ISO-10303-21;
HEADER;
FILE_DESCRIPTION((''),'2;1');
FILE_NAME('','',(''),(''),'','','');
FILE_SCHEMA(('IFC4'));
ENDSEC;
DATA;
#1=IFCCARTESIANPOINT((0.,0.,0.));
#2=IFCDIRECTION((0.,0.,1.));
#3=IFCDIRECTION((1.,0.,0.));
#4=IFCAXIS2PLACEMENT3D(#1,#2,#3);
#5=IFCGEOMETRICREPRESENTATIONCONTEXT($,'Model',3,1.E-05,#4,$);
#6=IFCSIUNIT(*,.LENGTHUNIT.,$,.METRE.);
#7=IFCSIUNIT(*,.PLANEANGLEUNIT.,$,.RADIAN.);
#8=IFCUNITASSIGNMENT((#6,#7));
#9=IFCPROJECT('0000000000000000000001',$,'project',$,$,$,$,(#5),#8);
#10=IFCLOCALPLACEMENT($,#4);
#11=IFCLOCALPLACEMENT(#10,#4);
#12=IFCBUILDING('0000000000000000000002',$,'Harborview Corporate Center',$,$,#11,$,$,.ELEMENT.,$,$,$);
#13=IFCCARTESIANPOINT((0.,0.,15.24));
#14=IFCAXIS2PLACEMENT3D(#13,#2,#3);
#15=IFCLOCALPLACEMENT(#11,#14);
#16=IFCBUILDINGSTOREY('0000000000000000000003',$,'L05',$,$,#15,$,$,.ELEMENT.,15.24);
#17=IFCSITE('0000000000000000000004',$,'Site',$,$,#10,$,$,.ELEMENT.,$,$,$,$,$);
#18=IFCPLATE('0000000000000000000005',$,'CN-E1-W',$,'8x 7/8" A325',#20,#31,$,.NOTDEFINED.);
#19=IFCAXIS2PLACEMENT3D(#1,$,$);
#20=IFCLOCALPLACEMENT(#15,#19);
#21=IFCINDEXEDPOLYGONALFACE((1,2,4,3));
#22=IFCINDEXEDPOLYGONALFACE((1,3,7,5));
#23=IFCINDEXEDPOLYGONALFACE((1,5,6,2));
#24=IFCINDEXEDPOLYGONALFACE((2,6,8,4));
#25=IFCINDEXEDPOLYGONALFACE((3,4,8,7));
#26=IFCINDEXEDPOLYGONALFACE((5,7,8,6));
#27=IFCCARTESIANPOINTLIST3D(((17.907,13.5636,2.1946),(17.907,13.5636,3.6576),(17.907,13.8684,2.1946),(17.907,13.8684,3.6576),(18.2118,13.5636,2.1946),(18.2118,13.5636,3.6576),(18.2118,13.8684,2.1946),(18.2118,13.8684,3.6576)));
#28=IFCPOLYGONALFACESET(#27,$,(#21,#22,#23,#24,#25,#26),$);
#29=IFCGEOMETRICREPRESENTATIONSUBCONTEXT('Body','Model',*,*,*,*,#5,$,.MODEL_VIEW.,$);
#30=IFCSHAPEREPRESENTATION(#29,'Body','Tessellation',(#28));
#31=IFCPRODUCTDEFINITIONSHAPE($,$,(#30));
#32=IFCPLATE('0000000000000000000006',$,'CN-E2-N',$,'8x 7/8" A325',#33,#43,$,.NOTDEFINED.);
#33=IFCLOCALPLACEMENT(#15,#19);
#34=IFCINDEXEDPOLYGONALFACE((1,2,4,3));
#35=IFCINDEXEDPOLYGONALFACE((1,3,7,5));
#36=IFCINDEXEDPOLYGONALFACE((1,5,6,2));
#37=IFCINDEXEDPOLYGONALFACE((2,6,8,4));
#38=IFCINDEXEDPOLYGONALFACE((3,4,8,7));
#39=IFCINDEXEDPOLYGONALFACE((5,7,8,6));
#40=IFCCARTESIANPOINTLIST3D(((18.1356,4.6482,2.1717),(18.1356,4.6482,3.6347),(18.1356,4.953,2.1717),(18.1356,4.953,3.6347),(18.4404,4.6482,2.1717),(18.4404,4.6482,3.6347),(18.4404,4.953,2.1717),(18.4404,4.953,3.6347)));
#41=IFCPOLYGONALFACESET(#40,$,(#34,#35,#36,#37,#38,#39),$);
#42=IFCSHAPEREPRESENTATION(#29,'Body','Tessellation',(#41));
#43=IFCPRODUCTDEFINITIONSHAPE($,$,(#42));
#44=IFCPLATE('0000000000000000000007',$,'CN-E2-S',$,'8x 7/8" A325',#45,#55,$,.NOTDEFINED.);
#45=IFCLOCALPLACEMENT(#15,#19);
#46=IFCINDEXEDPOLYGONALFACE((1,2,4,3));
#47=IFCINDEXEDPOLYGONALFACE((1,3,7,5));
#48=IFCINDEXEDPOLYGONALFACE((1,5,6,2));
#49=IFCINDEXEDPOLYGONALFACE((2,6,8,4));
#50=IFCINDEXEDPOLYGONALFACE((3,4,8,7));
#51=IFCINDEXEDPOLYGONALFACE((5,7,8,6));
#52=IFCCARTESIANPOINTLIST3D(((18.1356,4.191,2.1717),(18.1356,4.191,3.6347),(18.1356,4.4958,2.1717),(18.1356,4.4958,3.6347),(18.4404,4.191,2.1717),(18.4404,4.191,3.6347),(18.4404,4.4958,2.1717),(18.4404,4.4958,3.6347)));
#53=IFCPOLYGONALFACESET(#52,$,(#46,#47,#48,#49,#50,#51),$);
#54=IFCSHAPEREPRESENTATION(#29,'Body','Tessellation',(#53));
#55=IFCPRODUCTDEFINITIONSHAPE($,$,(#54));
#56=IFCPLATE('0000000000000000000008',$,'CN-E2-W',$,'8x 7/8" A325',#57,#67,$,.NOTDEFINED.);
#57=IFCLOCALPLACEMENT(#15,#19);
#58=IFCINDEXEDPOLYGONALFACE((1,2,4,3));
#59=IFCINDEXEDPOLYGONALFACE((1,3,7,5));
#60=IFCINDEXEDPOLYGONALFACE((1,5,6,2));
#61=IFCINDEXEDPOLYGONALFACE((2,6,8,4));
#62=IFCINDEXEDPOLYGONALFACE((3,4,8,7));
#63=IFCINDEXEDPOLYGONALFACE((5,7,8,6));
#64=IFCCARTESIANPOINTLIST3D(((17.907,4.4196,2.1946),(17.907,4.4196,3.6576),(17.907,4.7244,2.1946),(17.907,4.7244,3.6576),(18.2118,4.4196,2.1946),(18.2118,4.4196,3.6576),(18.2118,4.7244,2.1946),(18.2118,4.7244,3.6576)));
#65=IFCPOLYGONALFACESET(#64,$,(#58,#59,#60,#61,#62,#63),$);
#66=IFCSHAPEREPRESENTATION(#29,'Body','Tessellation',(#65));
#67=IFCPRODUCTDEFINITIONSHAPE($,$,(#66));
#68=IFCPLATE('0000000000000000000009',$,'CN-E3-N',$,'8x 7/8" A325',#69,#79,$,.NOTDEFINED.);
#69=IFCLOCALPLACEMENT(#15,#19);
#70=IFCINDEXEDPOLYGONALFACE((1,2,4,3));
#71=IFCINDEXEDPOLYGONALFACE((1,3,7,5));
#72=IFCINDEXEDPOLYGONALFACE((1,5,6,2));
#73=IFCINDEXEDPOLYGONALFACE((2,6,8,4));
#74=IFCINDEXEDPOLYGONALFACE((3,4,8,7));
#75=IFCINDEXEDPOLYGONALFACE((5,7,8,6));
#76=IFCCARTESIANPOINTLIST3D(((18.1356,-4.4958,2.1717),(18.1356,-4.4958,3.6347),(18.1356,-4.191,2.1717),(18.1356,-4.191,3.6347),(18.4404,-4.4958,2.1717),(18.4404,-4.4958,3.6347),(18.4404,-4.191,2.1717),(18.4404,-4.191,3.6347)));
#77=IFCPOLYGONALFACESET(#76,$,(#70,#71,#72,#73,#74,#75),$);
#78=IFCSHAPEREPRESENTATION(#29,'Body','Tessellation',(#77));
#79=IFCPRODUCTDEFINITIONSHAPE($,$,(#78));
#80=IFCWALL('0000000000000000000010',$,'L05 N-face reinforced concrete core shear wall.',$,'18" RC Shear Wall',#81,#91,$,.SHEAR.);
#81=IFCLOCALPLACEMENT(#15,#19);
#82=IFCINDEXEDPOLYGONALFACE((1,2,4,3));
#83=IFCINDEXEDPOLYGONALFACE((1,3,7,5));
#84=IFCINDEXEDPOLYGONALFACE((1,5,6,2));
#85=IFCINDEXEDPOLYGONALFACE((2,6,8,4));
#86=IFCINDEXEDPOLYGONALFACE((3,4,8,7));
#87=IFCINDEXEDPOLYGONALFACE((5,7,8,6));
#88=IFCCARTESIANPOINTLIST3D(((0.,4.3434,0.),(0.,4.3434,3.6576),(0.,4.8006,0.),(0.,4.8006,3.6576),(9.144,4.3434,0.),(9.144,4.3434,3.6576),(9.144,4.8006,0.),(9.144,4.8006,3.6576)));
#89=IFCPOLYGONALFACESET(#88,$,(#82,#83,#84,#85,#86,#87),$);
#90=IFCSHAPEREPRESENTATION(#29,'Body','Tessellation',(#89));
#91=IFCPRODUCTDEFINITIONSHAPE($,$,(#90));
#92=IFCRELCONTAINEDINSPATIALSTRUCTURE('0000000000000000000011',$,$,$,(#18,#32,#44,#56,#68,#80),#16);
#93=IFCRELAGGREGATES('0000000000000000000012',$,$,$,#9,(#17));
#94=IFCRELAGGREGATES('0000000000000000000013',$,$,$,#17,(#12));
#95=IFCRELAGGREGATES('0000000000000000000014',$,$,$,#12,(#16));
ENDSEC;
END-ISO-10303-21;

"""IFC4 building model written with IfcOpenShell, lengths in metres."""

from ifc_helpers import new_model, si_unit, frame, origin_with_axes, place, context, subcontext, project, spatial, rectangle, extrude, element, save


model = new_model("IFC4")

# Units and contexts
model_context = context("Model", 3, precision=1e-05, world=origin_with_axes())
body_context = subcontext(model_context, "Body", "Model", "MODEL_VIEW")
ifc_project = project(units=[si_unit("LENGTHUNIT", "METRE"), si_unit("PLANEANGLEUNIT", "RADIAN")], contexts=[model_context])

# Site, building, storey
site_placement = place(None, origin_with_axes())
site = spatial("IfcSite", under=ifc_project, at=site_placement, Name="Site", CompositionType="ELEMENT")
building_placement = place(site_placement, origin_with_axes())
building = spatial("IfcBuilding", under=site, at=building_placement, Name="Harborview Corporate Center", CompositionType="ELEMENT")
storey_placement = place(building_placement, frame((0.0, 0.0, 15.24), z_axis=(0.0, 0.0, 1.0), x_axis=(1.0, 0.0, 0.0)))
storey = spatial("IfcBuildingStorey", under=building, at=storey_placement, Name="L05", CompositionType="ELEMENT", Elevation=15.24)

# Plates
for number, where, z_axis, x_axis, name in (
    (1, (18.0594, 13.716, 2.1946), (0.0, 0.0, 1.0), (1.0, 0.0, 0.0), "CN-E1-W"),
    (2, (18.288, 4.8006, 2.1717), (0.0, 0.0, 1.0), (1.0, 0.0, 0.0), "CN-E2-N"),
    (3, (18.288, 4.3434, 2.1717), (0.0, 0.0, 1.0), (1.0, 0.0, 0.0), "CN-E2-S"),
    (4, (18.0594, 4.572, 2.1946), (0.0, 0.0, 1.0), (1.0, 0.0, 0.0), "CN-E2-W"),
    (5, (18.288, -4.3434, 2.1717), (0.0, 0.0, 1.0), (1.0, 0.0, 0.0), "CN-E3-N"),
):
    element("IfcPlate", number, at=place(storey_placement, frame(where, z_axis=z_axis, x_axis=x_axis)), inside=storey, Name=name, ObjectType="8x 7/8\" A325", PredefinedType="NOTDEFINED", context=body_context, shape_type="SweptSolid", body=[
        extrude(rectangle(XDim=0.3048, YDim=0.3048), origin_with_axes(), (0.0, 0.0, 1.0), 1.463),
    ])

# Wall
wall_placement = place(storey_placement, frame((4.572, 4.572, 0.0), z_axis=(0.0, 0.0, 1.0), x_axis=(1.0, 0.0, 0.0)))
element("IfcWall", 6, at=wall_placement, inside=storey, Name="L05 N-face reinforced concrete core shear wall.", ObjectType="18\" RC Shear Wall", PredefinedType="SHEAR", context=body_context, shape_type="SweptSolid", body=[
    extrude(rectangle(XDim=9.144, YDim=0.4572), origin_with_axes(), (0.0, 0.0, 1.0), 3.6576),
])

save(model, "model.ifc")
